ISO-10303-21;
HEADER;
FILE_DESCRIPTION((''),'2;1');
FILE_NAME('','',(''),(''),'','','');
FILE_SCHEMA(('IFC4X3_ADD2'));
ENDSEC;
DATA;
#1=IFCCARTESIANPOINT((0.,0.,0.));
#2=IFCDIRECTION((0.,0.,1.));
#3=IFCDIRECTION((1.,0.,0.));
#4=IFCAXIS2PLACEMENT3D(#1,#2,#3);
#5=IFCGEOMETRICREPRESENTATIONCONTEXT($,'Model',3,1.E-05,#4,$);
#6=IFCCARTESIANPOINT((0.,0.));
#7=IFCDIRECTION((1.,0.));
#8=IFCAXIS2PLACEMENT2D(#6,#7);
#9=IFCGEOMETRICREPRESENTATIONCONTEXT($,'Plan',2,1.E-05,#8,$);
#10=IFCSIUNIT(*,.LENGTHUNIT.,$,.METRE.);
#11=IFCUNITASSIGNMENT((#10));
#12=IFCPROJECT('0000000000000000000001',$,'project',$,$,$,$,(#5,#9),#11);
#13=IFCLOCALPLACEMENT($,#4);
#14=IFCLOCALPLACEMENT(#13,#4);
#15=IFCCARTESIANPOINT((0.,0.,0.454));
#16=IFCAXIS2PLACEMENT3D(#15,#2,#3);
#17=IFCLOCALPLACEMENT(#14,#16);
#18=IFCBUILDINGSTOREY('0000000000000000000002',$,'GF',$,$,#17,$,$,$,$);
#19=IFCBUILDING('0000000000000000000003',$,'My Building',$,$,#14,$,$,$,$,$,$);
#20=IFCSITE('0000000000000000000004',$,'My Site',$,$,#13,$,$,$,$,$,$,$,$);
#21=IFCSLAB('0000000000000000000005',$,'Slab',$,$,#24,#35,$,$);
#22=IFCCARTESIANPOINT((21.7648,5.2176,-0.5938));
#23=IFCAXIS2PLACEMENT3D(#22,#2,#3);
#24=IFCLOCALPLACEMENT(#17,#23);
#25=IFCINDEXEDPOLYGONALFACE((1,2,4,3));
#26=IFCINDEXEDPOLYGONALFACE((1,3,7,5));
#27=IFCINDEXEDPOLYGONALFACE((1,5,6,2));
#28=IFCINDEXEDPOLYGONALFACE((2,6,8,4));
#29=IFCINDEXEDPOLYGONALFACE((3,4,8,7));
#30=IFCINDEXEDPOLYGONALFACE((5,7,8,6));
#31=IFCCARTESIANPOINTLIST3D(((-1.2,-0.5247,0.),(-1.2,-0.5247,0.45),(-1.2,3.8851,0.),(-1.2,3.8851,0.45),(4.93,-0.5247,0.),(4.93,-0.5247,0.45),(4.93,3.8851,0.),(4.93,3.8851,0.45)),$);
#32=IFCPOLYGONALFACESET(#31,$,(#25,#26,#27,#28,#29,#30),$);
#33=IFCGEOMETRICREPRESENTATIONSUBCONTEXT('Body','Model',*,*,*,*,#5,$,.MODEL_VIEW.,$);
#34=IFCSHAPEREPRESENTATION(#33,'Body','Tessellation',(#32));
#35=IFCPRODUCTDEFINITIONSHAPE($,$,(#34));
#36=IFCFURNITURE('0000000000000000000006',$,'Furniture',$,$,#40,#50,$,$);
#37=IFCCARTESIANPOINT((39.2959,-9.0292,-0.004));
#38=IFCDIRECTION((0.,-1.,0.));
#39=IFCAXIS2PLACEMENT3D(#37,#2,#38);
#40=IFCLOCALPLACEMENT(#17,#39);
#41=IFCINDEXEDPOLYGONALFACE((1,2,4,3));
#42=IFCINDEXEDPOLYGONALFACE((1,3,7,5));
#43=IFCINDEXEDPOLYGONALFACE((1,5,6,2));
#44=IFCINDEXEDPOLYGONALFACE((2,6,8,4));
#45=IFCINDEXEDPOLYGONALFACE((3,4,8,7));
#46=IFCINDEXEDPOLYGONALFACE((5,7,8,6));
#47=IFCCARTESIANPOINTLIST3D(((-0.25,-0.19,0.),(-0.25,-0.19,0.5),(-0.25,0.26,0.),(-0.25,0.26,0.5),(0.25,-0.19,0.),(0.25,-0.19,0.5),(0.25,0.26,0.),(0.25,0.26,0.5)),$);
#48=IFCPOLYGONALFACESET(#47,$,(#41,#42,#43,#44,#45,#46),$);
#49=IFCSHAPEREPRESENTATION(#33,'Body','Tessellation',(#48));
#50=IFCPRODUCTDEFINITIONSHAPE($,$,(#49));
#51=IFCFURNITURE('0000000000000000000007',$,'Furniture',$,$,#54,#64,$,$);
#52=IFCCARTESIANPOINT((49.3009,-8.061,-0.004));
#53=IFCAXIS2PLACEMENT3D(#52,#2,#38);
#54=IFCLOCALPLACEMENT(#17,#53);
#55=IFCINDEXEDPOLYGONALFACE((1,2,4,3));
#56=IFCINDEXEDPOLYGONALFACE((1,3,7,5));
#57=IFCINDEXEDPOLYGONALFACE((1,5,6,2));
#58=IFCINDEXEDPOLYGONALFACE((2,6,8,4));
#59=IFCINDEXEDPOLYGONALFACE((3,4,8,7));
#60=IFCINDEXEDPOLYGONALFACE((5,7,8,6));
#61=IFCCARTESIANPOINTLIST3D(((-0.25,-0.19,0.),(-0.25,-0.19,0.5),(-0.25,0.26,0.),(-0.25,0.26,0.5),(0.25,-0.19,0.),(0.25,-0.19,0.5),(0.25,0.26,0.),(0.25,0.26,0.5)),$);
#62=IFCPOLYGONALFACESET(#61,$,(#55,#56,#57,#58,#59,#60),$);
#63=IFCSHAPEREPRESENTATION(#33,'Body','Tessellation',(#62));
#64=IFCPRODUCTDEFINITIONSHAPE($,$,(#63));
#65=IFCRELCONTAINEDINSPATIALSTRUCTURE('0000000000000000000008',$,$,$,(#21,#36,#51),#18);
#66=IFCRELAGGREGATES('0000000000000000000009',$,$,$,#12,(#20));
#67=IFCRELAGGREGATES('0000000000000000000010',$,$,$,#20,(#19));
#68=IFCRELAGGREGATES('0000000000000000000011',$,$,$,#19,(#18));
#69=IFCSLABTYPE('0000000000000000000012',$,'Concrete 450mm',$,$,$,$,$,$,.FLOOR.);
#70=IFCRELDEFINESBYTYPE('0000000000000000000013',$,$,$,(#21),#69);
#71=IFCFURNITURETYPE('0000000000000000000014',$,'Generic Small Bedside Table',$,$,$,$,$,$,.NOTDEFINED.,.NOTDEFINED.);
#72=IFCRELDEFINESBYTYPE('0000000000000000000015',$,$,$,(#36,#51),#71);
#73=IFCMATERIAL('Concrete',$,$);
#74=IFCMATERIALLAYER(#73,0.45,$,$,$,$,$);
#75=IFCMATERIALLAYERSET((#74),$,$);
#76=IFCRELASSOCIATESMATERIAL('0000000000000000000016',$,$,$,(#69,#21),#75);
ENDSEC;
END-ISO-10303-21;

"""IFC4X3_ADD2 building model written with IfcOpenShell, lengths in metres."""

from ifc_helpers import new_model, entity, si_unit, frame, origin_with_axes, origin_2d_with_axis, place, context, subcontext, project, spatial, line, indexed_curve, outline, extrude, shape, source, transform, mapped, material, layer, layer_set, layer_usage, type_object, type_shapes, element, save


model = new_model("IFC4X3_ADD2")

# Units and contexts
model_context = context("Model", 3, precision=1e-05, world=origin_with_axes())
plan_context = context("Plan", 2, precision=1e-05, world=origin_2d_with_axis())
body_context_1 = subcontext(model_context, "Body", "Model", "MODEL_VIEW")
body_context_2 = subcontext(plan_context, "Body", "Plan", "PLAN_VIEW")
ifc_project = project(units=[si_unit("LENGTHUNIT", "METRE")], contexts=[model_context, plan_context])

# Site, building, storey
site_placement = place(None, origin_with_axes())
site = spatial("IfcSite", under=ifc_project, at=site_placement, Name="My Site")
building_placement = place(site_placement, origin_with_axes())
building = spatial("IfcBuilding", under=site, at=building_placement, Name="My Building")
storey_placement = place(building_placement, frame((0.0, 0.0, 0.454), z_axis=(0.0, 0.0, 1.0), x_axis=(1.0, 0.0, 0.0)))
storey = spatial("IfcBuildingStorey", under=building, at=storey_placement, Name="GF")

# Slab
ifc_material_1 = material(Name="Concrete")
ifc_layer = layer(ifc_material_1, 0.45)
ifc_layer_set = layer_set([ifc_layer])
ifc_layer_usage = layer_usage(ifc_layer_set, "AXIS3", "POSITIVE", 0.0)
slab_type = type_object("IfcSlabType", Name="Concrete 450mm", PredefinedType="FLOOR", material=ifc_layer_set)
slab_placement = place(storey_placement, frame((21.7648, 5.2176, -0.5938), z_axis=(0.0, 0.0, 1.0), x_axis=(1.0, 0.0, 0.0)))
element("IfcSlab", 1, at=slab_placement, inside=storey, type_object=slab_type, material=ifc_layer_usage, Name="Slab", context=body_context_1, shape_type="SweptSolid", body=[
    extrude(outline(indexed_curve([(-1.2, -0.5247), (-1.2, 3.8851), (4.93, 3.8851), (4.93, -0.5247)], segments=[line(3, 2), line(2, 1), line(1, 4), line(4, 3)], self_intersect=False)), None, (0.0, 0.0, 1.0), 0.45),
])

# Furniture
furniture_type_1 = type_object("IfcFurnitureType", Name="Generic Small Bedside Table", AssemblyPlace="NOTDEFINED", PredefinedType="NOTDEFINED")
shared_shape_1 = source(origin_with_axes(), body_context_1, "Body", "SweptSolid", [
    extrude(outline(indexed_curve([(0.5, 0.45), (0.5, 0.0), (0.0, 0.0), (0.0, 0.45)], segments=[line(4, 1), line(1, 2), line(2, 3), line(3, 4)], self_intersect=False)), frame((-0.25, -0.19, 0.0), z_axis=(0.0, 0.0, 1.0), x_axis=(1.0, 0.0, 0.0)), (0.0, 0.0, 1.0), 0.5),
])
shared_shape_2 = source(origin_with_axes(), body_context_2, "Body", "Annotation2D", [
    entity("IfcGeometricCurveSet", [entity("IfcIndexedPolyCurve", entity("IfcCartesianPointList2D", [[-0.25, -0.19], [0.25, -0.19], [0.25, 0.26], [-0.25, 0.26]]), [entity("IfcLineIndex", [1, 2]), entity("IfcLineIndex", [2, 3]), entity("IfcLineIndex", [3, 4]), entity("IfcLineIndex", [4, 1])])]),
])
type_shapes(furniture_type_1, [shared_shape_1, shared_shape_2])
for number, where, z_axis, x_axis, name in (
    (2, (39.2959, -9.0292, -0.004), (0.0, 0.0, 1.0), (0.0, -1.0, 0.0), "Furniture"),
    (3, (49.3009, -8.061, -0.004), (0.0, 0.0, 1.0), (0.0, -1.0, 0.0), "Furniture"),
):
    element("IfcFurniture", number, at=place(storey_placement, frame(where, z_axis=z_axis, x_axis=x_axis)), inside=storey, type_object=furniture_type_1, Name=name, shapes=[
        shape(body_context_1, "Body", "MappedRepresentation", [mapped(shared_shape_1, transform((0.0, 0.0, 0.0), x_axis=(1.0, 0.0, 0.0), y_axis=(0.0, 1.0, 0.0), z_axis=(0.0, 0.0, 1.0), scale=1.0))]),
        shape(body_context_2, "Body", "MappedRepresentation", [mapped(shared_shape_2, transform((0.0, 0.0, 0.0), x_axis=(1.0, 0.0, 0.0), y_axis=(0.0, 1.0, 0.0), z_axis=(0.0, 0.0, 1.0), scale=1.0))]),
    ])

save(model, "model.ifc")
